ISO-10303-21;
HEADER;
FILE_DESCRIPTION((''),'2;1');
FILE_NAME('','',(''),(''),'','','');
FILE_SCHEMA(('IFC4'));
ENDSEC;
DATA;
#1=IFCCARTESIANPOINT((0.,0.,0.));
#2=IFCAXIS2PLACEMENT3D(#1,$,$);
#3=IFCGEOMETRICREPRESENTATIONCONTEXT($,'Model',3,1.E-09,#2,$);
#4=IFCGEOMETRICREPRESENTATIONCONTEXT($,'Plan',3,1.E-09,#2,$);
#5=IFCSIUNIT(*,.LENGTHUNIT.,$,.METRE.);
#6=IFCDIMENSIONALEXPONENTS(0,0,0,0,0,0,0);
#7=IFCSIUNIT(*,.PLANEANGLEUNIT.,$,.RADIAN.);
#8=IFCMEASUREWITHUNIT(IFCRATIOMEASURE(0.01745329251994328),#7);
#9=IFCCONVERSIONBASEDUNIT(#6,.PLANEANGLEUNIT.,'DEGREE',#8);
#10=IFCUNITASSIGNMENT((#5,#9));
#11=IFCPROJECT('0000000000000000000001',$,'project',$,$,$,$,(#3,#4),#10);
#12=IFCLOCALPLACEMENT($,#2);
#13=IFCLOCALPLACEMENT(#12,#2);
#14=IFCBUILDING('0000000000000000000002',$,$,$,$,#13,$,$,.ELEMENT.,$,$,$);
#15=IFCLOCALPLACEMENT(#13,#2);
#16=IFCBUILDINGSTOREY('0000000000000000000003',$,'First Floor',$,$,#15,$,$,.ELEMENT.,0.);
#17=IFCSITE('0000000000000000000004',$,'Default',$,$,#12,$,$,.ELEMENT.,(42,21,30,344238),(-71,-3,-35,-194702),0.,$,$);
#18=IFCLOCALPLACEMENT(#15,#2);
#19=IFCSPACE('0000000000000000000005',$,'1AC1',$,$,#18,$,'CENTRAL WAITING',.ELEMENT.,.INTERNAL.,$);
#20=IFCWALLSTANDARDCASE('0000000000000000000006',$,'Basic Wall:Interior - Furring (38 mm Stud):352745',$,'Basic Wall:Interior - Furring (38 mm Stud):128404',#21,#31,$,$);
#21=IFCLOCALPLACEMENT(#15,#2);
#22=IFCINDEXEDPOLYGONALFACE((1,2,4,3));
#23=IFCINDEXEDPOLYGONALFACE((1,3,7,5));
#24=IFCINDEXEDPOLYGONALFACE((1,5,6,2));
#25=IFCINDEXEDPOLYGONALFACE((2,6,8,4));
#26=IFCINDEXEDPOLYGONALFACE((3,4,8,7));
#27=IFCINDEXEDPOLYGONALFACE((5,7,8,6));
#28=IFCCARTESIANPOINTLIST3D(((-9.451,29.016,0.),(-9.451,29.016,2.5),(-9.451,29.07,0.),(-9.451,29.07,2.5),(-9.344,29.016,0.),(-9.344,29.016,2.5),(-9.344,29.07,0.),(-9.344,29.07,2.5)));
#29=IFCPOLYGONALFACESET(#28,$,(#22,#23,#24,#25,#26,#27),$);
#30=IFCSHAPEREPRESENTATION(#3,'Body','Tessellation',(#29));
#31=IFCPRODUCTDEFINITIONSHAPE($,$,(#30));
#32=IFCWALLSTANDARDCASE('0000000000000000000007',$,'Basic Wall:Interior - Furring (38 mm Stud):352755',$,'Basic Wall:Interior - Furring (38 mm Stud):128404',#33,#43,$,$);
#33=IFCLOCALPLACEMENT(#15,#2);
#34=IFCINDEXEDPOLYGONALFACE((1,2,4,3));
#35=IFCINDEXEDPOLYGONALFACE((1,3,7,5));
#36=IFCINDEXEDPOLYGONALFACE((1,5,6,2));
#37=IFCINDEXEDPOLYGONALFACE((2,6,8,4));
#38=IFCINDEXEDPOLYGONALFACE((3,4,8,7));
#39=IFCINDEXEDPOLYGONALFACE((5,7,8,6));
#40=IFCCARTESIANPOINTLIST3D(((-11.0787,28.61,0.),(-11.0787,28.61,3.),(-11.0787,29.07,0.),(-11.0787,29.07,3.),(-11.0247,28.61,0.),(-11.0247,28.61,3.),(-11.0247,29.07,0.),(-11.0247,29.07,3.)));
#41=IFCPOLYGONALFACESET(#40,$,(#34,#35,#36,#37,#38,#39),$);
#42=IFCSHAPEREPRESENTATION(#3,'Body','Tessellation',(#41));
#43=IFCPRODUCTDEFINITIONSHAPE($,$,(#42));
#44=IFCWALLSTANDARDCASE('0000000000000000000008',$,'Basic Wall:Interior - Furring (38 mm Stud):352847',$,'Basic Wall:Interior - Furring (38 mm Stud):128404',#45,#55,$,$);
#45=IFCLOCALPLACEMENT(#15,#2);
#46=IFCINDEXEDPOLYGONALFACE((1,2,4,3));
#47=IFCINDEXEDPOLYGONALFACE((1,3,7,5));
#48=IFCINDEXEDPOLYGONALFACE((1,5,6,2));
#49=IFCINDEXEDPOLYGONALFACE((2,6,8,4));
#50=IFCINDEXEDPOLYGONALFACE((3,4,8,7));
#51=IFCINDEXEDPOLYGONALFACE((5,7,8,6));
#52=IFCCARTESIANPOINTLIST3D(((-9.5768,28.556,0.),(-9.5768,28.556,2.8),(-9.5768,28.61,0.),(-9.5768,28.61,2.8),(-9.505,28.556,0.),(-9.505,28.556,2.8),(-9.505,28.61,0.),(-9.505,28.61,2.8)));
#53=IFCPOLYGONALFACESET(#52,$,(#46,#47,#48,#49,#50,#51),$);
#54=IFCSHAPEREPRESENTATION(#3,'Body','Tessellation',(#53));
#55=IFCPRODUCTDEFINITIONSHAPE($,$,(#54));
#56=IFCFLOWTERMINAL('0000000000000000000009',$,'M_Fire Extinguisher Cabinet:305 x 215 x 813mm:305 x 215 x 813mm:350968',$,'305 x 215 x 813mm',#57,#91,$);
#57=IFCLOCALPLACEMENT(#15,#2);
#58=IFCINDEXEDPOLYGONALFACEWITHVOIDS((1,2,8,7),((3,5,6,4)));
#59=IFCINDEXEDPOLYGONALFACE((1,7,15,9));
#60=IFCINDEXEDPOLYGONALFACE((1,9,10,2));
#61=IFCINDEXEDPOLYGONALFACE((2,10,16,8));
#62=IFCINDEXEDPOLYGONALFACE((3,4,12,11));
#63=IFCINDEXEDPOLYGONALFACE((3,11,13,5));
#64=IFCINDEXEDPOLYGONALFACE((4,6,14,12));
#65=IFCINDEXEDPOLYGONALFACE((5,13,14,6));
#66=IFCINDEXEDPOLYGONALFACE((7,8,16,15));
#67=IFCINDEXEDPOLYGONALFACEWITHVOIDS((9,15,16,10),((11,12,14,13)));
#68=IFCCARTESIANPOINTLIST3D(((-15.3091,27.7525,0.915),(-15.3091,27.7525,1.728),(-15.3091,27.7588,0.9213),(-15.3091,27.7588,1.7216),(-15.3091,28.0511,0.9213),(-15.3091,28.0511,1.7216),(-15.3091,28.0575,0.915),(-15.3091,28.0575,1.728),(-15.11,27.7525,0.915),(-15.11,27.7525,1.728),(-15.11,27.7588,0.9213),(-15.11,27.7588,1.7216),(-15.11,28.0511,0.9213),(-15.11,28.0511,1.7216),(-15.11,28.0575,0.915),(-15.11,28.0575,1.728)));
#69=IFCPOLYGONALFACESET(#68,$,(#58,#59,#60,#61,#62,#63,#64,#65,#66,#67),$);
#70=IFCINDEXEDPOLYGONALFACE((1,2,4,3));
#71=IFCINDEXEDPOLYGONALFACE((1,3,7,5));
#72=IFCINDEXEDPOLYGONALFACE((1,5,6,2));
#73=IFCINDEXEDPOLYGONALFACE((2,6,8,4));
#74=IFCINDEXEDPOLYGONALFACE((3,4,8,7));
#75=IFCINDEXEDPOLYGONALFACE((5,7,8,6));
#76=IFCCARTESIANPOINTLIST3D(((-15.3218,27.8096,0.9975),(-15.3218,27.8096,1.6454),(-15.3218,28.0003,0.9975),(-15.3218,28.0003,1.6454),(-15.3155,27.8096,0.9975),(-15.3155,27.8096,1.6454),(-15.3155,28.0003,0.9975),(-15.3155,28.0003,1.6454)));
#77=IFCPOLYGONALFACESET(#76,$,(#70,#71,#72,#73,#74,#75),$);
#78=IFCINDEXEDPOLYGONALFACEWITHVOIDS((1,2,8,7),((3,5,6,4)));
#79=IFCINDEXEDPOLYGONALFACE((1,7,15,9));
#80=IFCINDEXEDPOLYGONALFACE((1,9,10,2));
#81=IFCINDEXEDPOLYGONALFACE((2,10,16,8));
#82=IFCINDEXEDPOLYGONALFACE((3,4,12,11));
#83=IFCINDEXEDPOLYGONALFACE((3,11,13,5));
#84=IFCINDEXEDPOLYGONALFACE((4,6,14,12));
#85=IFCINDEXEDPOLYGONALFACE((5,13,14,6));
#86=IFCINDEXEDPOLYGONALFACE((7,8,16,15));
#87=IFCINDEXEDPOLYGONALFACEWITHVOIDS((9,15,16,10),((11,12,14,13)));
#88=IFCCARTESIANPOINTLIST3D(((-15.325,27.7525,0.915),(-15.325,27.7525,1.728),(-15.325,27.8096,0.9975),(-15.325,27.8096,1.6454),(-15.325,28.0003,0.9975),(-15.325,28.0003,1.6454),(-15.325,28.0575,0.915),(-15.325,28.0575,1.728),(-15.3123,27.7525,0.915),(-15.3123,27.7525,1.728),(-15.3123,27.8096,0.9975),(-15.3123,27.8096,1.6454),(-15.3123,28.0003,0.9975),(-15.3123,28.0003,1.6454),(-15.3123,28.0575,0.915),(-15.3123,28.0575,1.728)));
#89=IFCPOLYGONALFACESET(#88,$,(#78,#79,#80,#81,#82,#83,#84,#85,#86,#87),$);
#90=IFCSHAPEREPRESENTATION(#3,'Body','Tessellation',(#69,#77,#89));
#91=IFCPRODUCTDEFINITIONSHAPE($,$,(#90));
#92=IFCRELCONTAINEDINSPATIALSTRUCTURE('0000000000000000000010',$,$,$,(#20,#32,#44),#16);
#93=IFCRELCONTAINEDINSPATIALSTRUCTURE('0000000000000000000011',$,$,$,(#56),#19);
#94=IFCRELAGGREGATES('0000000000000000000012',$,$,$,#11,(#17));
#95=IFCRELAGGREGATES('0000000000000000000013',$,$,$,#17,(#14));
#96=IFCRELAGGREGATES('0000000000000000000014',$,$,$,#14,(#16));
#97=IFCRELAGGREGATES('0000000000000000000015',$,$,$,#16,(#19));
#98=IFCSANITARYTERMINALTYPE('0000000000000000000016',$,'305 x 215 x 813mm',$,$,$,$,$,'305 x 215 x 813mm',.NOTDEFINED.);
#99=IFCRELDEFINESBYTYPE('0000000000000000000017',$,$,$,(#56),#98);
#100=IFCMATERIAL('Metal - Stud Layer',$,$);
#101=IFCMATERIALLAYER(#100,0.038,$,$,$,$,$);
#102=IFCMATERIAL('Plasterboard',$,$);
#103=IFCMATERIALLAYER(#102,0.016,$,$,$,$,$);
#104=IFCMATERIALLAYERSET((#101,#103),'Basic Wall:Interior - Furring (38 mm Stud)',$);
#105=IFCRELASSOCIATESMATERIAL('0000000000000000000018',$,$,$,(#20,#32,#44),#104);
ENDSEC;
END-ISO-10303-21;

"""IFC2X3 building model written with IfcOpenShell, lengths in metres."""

from ifc_helpers import new_model, entity, si_unit, converted_unit, frame, frame_2d, origin, origin_2d_with_axis, place, context, project, spatial, rectangle, extrude, source, transform, mapped, material, layer, layer_set, layer_usage, type_object, type_shapes, element, save


model = new_model("IFC2X3")

# Units and contexts
model_context = context("Model", 3, precision=1e-09, world=origin())
plan_context = context("Plan", 3, precision=1e-09, world=origin())
ifc_project = project(units=[si_unit("LENGTHUNIT", "METRE"), converted_unit("PLANEANGLEUNIT", "DEGREE", entity("IfcRatioMeasure", 0.01745329251994328), si_unit("PLANEANGLEUNIT", "RADIAN"), dimensions=[0, 0, 0, 0, 0, 0, 0])], contexts=[model_context, plan_context])

# Site, building, storey
site_placement = place(None, origin())
site = spatial("IfcSite", under=ifc_project, at=site_placement, Name="Default", CompositionType="ELEMENT", RefLatitude=(42, 21, 30, 344238), RefLongitude=(-71, -3, -35, -194702), RefElevation=0.0)
building_placement = place(site_placement, origin())
building = spatial("IfcBuilding", under=site, at=building_placement, CompositionType="ELEMENT")
storey_placement = place(building_placement, origin())
storey = spatial("IfcBuildingStorey", under=building, at=storey_placement, Name="First Floor", CompositionType="ELEMENT", Elevation=0.0)

# Shared definitions
ifc_material_1 = material(Name="Metal - Stud Layer")

# Shared definitions
ifc_layer_1 = layer(ifc_material_1, 0.038)
ifc_material_2 = material(Name="Plasterboard")
ifc_layer_2 = layer(ifc_material_2, 0.016)
ifc_layer_set_1 = layer_set([ifc_layer_1, ifc_layer_2], Name="Basic Wall:Interior - Furring (38 mm Stud)")
ifc_layer_usage_1 = layer_usage(ifc_layer_set_1, "AXIS2", "POSITIVE", -0.027)

# Walls
ifc_layer_usage_2 = layer_usage(ifc_layer_set_1, "AXIS2", "NEGATIVE", 0.027)
wall_1_placement = place(storey_placement, frame((-9.451, 29.043, 0.0)))
element("IfcWallStandardCase", 1, at=wall_1_placement, inside=storey, material=ifc_layer_usage_1, Name="Basic Wall:Interior - Furring (38 mm Stud):352745", ObjectType="Basic Wall:Interior - Furring (38 mm Stud):128404", context=model_context, shape_type="SweptSolid", body=[
    extrude(rectangle(XDim=0.107, YDim=0.054, at=frame_2d((0.0535, 0.0), x_axis=(-1.0, 0.0))), origin(), (0.0, 0.0, 1.0), 2.5),
])
wall_2_placement = place(storey_placement, frame((-11.0517, 28.61, 0.0), z_axis=(0.0, 0.0, 1.0), x_axis=(0.0, 1.0, 0.0)))
element("IfcWallStandardCase", 2, at=wall_2_placement, inside=storey, material=ifc_layer_usage_1, Name="Basic Wall:Interior - Furring (38 mm Stud):352755", ObjectType="Basic Wall:Interior - Furring (38 mm Stud):128404", context=model_context, shape_type="SweptSolid", body=[
    extrude(rectangle(XDim=0.46, YDim=0.054, at=frame_2d((0.23, 0.0), x_axis=(-1.0, 0.0))), origin(), (0.0, 0.0, 1.0), 3.0),
])
wall_3_placement = place(storey_placement, frame((-9.505, 28.583, 0.0), z_axis=(0.0, 0.0, 1.0), x_axis=(-1.0, 0.0, 0.0)))
element("IfcWallStandardCase", 3, at=wall_3_placement, inside=storey, material=ifc_layer_usage_2, Name="Basic Wall:Interior - Furring (38 mm Stud):352847", ObjectType="Basic Wall:Interior - Furring (38 mm Stud):128404", context=model_context, shape_type="SweptSolid", body=[
    extrude(rectangle(XDim=0.0719, YDim=0.054, at=frame_2d((0.0359, 0.0), x_axis=(-1.0, 0.0))), origin(), (0.0, 0.0, 1.0), 2.8),
])

# Shared definitions
space_placement = place(storey_placement, origin())
space = spatial("IfcSpace", under=storey, at=space_placement, Name="1AC1", LongName="CENTRAL WAITING", CompositionType="ELEMENT", InteriorOrExteriorSpace="INTERNAL")

# Flow terminal
sanitary_terminal_type = type_object("IfcSanitaryTerminalType", Name="305 x 215 x 813mm", ElementType="305 x 215 x 813mm", PredefinedType="NOTDEFINED")
cartesian_point_1 = entity("IfcCartesianPoint", [-0.1525, -0.4065])
shared_polyline = entity("IfcPolyline", [cartesian_point_1, entity("IfcCartesianPoint", [0.1525, -0.4065]), entity("IfcCartesianPoint", [0.1525, 0.4065]), entity("IfcCartesianPoint", [-0.1525, 0.4065]), cartesian_point_1])
cartesian_point_2 = entity("IfcCartesianPoint", [-0.1462, -0.4001])
cartesian_point_3 = entity("IfcCartesianPoint", [-0.0953, -0.3239])
shared_shape_1 = source(origin(), model_context, "Body", "SweptSolid", [
    entity("IfcExtrudedAreaSolid", entity("IfcArbitraryProfileDefWithVoids", "AREA", None, shared_polyline, [entity("IfcPolyline", [cartesian_point_2, entity("IfcCartesianPoint", [-0.1462, 0.4002]), entity("IfcCartesianPoint", [0.1462, 0.4002]), entity("IfcCartesianPoint", [0.1462, -0.4001]), cartesian_point_2])]), entity("IfcAxis2Placement3D", entity("IfcCartesianPoint", [-0.1096, 0.062, 1.3215]), entity("IfcDirection", [0.0, 1.0, 0.0]), entity("IfcDirection", [1.0, 0.0, 0.0])), entity("IfcDirection", [0.0, 0.0, 1.0]), 0.1991),
    extrude(rectangle(XDim=0.0064, YDim=0.1907, at=origin_2d_with_axis()), frame((-0.1096, 0.2706, 0.9975), z_axis=(0.0, 0.0, 1.0), x_axis=(0.0, -1.0, 0.0)), (0.0, 0.0, 1.0), 0.6479),
    entity("IfcExtrudedAreaSolid", entity("IfcArbitraryProfileDefWithVoids", "AREA", None, shared_polyline, [entity("IfcPolyline", [cartesian_point_3, entity("IfcCartesianPoint", [-0.0953, 0.324]), entity("IfcCartesianPoint", [0.0954, 0.324]), entity("IfcCartesianPoint", [0.0954, -0.3239]), cartesian_point_3])]), entity("IfcAxis2Placement3D", entity("IfcCartesianPoint", [-0.1096, 0.2643, 1.3215]), entity("IfcDirection", [0.0, 1.0, 0.0]), entity("IfcDirection", [1.0, 0.0, 0.0])), entity("IfcDirection", [0.0, 0.0, 1.0]), 0.0127),
])
type_shapes(sanitary_terminal_type, [shared_shape_1])
flow_terminal_placement = place(space_placement, frame((-15.048, 28.0146, 0.0), z_axis=(0.0, 0.0, 1.0), x_axis=(0.0, 1.0, 0.0)))
element("IfcFlowTerminal", 4, at=flow_terminal_placement, inside=space, type_object=sanitary_terminal_type, Name="M_Fire Extinguisher Cabinet:305 x 215 x 813mm:305 x 215 x 813mm:350968", ObjectType="305 x 215 x 813mm", context=model_context, shape_type="MappedRepresentation", body=[
    mapped(shared_shape_1, transform((0.0, 0.0, 0.0), scale=1.0)),
])

save(model, "model.ifc")
